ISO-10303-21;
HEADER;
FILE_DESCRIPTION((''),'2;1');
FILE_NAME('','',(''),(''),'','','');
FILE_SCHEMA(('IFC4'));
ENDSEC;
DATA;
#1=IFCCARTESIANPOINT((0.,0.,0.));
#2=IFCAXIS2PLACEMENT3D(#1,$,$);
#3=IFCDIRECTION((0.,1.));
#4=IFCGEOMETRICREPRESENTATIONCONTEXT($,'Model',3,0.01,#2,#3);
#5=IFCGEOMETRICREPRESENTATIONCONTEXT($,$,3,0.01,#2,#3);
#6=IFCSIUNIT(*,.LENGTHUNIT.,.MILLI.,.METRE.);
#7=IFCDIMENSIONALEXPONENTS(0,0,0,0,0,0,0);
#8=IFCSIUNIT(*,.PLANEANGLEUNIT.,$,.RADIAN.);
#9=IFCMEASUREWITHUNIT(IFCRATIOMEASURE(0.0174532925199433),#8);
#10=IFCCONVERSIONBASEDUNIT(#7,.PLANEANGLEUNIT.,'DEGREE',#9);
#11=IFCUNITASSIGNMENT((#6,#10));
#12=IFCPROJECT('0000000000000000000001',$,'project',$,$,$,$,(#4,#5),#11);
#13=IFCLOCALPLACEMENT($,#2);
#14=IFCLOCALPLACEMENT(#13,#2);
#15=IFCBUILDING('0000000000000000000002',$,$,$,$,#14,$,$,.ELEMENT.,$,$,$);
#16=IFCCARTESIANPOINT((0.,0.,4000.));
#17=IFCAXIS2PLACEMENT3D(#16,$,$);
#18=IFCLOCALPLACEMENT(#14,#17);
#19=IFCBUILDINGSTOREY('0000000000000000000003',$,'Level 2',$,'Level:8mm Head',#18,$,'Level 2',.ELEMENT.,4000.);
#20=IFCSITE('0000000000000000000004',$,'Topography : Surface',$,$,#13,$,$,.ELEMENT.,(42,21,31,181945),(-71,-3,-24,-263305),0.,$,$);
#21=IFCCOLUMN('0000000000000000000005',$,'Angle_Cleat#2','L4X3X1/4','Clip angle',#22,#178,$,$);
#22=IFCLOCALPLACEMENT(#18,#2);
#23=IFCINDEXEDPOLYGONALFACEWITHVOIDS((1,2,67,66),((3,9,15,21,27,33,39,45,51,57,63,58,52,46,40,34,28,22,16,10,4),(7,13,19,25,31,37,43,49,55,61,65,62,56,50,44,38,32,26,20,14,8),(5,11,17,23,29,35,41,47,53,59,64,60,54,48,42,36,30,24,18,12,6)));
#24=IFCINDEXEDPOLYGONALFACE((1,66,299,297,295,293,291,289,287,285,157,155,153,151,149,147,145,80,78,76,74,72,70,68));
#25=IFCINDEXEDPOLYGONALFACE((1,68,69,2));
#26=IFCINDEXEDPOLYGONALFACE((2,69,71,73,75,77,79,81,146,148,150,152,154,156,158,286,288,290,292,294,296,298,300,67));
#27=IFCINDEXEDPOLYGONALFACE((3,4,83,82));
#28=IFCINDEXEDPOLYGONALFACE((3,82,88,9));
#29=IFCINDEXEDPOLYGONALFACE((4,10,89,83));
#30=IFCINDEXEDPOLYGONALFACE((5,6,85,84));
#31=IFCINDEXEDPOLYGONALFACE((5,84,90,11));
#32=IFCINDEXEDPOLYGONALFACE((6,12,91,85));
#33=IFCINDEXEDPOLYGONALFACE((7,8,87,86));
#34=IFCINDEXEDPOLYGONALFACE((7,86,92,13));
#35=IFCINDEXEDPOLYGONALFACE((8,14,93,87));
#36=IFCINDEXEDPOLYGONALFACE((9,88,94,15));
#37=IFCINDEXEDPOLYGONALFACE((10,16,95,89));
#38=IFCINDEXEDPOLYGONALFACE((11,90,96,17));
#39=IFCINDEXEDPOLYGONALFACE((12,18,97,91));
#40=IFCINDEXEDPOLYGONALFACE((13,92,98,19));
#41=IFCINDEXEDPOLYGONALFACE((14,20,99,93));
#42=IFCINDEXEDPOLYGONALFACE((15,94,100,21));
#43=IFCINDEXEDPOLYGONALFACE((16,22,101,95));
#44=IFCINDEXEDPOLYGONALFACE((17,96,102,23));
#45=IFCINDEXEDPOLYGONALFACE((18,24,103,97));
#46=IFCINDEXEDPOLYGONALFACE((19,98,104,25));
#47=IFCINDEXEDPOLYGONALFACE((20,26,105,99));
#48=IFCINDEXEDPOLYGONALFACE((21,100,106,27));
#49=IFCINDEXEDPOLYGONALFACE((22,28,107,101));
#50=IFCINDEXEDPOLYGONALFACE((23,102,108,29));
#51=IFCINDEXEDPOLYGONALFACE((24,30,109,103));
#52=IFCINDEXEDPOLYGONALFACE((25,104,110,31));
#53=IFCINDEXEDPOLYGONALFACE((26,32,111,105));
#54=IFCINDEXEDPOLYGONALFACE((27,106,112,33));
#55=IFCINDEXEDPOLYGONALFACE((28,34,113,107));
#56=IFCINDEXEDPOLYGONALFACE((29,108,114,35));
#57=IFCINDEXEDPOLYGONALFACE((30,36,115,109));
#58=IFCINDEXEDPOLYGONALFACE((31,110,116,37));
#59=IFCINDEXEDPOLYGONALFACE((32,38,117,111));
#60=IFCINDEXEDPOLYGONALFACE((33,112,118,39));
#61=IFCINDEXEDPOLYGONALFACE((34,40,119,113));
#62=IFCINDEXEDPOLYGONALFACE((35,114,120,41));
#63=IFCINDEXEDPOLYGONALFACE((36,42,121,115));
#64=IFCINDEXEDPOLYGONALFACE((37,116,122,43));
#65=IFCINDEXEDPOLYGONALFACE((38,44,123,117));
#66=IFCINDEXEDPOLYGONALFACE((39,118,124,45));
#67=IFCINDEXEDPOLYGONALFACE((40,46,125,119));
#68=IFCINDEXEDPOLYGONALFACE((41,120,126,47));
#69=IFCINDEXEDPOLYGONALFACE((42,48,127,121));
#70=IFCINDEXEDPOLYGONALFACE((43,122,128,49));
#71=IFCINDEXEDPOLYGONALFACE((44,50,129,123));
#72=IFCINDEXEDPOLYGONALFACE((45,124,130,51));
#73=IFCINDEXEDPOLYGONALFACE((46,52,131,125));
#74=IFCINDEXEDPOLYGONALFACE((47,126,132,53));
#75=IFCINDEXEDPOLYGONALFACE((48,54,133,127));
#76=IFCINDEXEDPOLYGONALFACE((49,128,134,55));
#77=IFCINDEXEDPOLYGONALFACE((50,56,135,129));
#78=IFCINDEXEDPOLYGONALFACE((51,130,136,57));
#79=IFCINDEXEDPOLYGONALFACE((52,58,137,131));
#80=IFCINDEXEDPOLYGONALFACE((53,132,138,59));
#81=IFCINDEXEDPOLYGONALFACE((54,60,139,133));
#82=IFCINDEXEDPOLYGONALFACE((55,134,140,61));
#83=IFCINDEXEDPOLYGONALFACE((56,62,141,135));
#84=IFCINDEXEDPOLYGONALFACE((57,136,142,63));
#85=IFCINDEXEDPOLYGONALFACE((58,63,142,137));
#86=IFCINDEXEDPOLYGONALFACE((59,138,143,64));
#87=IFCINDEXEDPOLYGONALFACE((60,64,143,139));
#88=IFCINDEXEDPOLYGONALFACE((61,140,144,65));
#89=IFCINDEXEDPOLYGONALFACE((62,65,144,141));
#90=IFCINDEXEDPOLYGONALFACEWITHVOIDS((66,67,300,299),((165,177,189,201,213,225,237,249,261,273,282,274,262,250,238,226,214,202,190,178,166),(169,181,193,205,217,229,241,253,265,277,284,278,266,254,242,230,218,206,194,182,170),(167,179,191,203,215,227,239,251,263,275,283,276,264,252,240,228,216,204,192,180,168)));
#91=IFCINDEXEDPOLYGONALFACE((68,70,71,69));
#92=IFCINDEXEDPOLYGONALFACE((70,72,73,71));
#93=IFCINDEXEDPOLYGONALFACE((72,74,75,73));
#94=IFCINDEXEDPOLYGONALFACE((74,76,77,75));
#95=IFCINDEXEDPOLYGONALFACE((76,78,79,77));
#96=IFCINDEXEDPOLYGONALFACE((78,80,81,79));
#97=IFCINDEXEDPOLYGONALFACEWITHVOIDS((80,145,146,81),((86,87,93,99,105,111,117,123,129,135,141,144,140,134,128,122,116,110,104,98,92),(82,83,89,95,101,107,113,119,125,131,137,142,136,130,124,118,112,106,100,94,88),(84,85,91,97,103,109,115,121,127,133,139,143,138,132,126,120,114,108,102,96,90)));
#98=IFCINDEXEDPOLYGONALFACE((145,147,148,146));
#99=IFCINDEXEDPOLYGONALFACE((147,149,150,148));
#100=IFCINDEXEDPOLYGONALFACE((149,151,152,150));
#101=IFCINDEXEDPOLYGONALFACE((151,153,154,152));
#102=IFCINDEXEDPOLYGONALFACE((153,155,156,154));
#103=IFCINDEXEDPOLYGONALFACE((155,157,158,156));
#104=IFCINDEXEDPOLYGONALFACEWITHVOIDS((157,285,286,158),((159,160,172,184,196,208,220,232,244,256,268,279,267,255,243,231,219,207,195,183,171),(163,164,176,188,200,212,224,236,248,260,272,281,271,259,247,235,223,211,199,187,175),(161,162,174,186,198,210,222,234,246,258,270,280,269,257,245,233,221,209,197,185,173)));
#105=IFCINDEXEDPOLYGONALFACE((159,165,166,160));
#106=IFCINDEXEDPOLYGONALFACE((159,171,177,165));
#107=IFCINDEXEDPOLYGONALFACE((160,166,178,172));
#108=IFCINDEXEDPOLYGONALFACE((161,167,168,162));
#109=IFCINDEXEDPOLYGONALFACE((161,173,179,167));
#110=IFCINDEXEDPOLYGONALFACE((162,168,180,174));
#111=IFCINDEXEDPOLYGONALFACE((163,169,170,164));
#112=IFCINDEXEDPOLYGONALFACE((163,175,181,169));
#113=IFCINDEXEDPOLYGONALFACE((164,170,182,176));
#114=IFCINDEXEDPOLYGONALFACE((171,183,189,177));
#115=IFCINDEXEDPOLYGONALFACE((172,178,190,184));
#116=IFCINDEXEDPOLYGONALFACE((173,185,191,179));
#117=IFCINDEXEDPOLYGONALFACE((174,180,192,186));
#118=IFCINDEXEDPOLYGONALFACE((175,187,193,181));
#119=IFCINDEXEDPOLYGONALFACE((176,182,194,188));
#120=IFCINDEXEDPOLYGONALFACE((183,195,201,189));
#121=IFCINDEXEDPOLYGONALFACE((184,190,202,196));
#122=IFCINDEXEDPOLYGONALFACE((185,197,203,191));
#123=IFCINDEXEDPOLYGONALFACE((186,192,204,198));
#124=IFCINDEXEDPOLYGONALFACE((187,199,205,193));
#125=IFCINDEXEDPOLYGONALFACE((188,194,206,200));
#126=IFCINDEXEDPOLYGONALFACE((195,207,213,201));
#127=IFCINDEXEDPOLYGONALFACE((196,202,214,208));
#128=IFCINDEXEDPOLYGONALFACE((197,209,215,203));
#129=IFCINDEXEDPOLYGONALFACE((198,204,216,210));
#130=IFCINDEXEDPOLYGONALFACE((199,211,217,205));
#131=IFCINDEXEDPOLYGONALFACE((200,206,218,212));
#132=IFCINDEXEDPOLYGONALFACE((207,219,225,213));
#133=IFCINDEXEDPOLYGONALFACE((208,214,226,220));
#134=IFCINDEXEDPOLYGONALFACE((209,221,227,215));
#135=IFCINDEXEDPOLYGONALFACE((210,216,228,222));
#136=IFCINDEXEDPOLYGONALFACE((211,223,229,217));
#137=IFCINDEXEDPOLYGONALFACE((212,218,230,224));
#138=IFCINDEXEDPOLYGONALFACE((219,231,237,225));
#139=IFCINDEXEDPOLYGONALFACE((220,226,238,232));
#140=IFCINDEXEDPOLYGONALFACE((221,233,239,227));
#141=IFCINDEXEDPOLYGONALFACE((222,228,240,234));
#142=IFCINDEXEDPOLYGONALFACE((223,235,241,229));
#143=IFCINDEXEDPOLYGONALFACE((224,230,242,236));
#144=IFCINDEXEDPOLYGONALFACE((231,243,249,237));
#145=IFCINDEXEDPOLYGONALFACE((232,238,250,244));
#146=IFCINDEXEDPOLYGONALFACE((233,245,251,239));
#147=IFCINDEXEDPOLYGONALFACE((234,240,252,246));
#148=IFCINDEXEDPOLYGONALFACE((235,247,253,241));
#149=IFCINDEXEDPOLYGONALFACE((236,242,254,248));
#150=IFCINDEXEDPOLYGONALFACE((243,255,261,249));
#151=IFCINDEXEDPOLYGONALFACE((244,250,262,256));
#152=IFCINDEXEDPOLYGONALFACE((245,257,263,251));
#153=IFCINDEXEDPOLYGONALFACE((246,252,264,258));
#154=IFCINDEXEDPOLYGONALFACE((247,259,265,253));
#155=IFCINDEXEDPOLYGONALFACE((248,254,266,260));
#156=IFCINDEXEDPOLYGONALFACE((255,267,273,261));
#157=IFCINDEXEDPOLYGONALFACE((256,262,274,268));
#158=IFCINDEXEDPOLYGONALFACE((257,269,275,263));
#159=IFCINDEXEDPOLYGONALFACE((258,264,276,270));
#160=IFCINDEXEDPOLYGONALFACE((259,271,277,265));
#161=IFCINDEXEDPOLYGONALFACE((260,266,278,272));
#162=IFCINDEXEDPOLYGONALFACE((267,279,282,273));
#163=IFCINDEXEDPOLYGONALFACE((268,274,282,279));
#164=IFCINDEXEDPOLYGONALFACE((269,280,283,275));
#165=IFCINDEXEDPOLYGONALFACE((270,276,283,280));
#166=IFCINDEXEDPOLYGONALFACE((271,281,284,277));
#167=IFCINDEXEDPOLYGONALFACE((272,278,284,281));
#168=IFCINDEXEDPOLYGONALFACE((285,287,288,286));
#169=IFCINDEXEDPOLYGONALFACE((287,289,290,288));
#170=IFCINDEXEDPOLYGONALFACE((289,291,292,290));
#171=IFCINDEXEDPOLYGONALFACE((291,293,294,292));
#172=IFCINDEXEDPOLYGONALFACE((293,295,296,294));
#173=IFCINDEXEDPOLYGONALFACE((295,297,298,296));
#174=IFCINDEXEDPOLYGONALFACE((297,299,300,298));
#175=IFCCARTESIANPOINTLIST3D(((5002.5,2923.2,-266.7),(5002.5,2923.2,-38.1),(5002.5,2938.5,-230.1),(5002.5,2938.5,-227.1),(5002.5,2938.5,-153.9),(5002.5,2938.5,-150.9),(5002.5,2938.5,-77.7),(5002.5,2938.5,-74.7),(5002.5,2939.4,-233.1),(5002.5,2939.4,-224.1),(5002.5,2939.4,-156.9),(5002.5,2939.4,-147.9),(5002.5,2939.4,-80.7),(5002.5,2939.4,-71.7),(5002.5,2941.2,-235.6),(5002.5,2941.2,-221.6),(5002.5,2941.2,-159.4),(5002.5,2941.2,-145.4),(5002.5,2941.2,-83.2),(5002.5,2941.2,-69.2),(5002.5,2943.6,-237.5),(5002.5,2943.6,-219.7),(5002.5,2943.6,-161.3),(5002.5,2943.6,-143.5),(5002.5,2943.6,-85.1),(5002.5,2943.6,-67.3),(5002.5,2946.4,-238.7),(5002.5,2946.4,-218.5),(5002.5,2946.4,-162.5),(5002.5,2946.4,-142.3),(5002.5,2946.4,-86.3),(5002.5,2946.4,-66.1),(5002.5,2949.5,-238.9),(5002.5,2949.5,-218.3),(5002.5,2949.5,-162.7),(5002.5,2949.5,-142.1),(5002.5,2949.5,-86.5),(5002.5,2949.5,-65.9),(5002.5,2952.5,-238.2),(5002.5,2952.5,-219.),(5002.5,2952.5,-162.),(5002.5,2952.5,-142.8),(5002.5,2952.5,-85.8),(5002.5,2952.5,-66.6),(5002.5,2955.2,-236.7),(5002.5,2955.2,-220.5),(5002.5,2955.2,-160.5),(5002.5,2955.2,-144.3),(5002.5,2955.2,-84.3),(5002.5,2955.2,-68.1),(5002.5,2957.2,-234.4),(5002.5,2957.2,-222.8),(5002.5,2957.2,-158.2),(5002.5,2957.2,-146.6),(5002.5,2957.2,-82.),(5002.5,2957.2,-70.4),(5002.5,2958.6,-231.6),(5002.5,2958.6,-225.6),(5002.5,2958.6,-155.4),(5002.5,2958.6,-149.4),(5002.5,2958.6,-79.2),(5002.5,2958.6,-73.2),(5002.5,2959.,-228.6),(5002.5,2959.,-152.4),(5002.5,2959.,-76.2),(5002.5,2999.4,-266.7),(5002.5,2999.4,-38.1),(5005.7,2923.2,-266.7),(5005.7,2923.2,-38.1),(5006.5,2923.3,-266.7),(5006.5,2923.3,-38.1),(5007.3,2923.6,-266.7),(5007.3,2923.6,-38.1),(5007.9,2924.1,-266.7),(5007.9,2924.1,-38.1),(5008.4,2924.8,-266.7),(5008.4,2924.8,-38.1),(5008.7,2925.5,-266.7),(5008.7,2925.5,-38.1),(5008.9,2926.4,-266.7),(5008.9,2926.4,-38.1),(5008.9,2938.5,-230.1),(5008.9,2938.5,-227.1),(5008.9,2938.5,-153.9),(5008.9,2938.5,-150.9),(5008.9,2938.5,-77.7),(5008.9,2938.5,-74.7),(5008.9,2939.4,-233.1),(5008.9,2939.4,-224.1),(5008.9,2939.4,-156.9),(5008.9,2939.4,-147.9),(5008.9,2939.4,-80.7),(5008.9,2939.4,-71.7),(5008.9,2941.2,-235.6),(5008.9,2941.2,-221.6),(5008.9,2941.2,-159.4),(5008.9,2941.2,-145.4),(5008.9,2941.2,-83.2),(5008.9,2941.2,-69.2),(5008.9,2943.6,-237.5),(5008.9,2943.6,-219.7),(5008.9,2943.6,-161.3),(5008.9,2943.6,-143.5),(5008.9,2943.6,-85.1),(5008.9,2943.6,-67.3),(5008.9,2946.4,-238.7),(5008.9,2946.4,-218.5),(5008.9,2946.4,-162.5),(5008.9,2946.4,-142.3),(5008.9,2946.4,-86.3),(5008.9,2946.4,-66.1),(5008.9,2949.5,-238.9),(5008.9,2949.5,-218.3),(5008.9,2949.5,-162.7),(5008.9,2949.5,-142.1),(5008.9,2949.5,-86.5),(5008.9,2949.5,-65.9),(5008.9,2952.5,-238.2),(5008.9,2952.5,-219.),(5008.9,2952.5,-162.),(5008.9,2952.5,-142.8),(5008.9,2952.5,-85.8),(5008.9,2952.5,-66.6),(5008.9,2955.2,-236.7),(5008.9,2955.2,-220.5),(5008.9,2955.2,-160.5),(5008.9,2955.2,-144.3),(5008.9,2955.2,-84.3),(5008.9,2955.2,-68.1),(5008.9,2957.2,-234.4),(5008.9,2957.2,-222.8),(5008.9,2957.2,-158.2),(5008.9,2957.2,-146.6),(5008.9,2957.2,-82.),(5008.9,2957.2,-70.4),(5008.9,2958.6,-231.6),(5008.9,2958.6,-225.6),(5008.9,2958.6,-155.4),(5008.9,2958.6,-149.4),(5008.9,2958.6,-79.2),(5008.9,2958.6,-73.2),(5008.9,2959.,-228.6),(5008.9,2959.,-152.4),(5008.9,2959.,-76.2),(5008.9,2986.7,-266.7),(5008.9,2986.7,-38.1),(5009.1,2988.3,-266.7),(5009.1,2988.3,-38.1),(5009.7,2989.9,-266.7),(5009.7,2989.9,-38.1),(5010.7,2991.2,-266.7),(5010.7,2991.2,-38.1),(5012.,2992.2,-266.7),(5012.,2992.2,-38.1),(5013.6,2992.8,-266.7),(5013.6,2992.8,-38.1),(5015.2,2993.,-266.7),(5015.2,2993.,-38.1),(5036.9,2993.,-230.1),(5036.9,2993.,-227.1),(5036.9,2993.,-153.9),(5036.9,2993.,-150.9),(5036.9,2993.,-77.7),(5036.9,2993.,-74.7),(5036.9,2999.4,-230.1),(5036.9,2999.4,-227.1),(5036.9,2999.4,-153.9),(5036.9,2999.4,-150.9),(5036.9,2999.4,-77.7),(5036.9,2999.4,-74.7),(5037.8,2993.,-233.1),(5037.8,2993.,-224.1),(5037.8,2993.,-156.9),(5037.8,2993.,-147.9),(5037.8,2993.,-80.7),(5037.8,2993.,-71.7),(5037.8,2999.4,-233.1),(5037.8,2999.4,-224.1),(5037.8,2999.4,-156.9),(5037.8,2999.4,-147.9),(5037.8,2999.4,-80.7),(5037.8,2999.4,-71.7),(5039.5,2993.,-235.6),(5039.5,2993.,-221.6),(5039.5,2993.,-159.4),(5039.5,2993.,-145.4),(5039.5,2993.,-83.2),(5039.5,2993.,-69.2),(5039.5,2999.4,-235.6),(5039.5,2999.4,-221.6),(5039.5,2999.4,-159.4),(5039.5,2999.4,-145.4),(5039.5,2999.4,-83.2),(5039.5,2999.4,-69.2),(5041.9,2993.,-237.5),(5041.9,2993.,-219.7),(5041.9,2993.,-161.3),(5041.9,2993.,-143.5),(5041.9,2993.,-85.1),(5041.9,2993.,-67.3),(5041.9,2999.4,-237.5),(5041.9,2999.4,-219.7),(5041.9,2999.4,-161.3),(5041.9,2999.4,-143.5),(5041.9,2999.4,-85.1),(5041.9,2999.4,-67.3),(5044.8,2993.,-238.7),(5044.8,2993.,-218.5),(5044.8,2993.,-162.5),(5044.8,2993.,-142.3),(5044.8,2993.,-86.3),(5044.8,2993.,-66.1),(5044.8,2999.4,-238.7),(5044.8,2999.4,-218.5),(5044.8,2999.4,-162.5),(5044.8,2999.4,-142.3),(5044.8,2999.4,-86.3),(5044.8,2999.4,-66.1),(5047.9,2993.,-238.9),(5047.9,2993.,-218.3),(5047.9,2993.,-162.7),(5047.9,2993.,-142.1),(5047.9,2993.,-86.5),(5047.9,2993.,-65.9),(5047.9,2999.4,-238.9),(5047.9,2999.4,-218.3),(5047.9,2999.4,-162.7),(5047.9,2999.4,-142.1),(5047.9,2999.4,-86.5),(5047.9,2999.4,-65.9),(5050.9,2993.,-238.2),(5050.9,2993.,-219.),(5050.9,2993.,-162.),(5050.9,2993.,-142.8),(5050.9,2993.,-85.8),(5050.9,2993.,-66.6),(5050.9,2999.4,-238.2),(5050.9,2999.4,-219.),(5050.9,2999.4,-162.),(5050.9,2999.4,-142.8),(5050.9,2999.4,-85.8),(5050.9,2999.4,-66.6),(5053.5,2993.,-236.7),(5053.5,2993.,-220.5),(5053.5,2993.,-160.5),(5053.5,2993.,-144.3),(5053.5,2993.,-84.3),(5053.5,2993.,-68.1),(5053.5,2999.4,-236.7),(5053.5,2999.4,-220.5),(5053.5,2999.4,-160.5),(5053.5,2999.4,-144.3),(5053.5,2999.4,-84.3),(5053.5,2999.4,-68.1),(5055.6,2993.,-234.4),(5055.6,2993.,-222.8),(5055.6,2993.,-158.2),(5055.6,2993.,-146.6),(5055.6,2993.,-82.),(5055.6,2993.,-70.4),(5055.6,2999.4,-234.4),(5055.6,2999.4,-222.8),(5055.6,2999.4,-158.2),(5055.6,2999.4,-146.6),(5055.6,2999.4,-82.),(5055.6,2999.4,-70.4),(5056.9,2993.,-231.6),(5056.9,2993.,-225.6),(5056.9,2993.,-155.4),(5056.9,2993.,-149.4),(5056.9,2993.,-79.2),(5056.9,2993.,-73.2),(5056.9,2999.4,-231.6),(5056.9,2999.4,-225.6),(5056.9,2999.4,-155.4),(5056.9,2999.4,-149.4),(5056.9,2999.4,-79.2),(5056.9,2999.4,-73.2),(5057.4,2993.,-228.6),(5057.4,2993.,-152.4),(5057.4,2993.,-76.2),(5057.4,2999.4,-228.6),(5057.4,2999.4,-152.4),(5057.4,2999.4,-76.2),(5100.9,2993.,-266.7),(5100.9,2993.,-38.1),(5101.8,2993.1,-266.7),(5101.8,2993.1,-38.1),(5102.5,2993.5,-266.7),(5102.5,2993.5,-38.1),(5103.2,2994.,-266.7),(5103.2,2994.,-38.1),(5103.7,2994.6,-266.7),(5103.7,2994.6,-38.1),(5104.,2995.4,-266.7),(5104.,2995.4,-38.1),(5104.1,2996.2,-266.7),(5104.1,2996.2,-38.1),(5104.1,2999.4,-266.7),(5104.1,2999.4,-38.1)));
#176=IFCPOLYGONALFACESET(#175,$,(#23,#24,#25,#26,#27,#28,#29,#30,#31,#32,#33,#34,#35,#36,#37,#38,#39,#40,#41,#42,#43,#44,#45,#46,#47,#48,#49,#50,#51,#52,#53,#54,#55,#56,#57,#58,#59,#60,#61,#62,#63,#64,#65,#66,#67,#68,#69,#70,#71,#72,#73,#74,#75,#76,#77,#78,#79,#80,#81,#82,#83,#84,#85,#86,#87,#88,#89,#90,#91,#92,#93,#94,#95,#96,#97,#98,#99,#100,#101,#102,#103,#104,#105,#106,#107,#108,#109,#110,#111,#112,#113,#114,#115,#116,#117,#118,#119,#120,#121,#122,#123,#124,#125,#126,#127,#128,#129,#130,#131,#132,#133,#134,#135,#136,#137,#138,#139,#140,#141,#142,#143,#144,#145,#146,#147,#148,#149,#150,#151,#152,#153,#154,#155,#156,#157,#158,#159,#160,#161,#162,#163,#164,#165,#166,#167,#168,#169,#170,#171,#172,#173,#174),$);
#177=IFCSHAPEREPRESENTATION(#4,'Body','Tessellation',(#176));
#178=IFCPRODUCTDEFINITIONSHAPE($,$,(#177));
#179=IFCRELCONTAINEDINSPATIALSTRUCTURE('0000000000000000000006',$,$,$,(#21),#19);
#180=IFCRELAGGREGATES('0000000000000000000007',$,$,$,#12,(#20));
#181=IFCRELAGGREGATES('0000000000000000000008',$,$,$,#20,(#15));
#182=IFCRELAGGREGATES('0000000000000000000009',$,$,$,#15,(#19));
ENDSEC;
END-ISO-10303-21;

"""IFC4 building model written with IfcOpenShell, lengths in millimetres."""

from ifc_helpers import new_model, entity, si_unit, converted_unit, direction, frame, frame_2d, origin, origin_2d_with_axis, place, context, project, spatial, circle, l_section, extrude, element, save


model = new_model("IFC4")

# Units and contexts
model_context = context("Model", 3, precision=0.01, world=origin(), true_north=direction((0.0, 1.0)))
context_of_model = context(None, 3, precision=0.01, world=origin(), true_north=direction((0.0, 1.0)))
ifc_project = project(units=[si_unit("LENGTHUNIT", "METRE", prefix="MILLI"), converted_unit("PLANEANGLEUNIT", "DEGREE", entity("IfcRatioMeasure", 0.0174532925199433), si_unit("PLANEANGLEUNIT", "RADIAN"), dimensions=[0, 0, 0, 0, 0, 0, 0])], contexts=[model_context, context_of_model])

# Site, building, storey
site_placement = place(None, origin())
site = spatial("IfcSite", under=ifc_project, at=site_placement, Name="Topography : Surface", CompositionType="ELEMENT", RefLatitude=(42, 21, 31, 181945), RefLongitude=(-71, -3, -24, -263305), RefElevation=0.0)
building_placement = place(site_placement, origin())
building = spatial("IfcBuilding", under=site, at=building_placement, CompositionType="ELEMENT")
storey_placement = place(building_placement, frame((0.0, 0.0, 4000.0)))
storey = spatial("IfcBuildingStorey", under=building, at=storey_placement, Name="Level 2", ObjectType="Level:8mm Head", LongName="Level 2", CompositionType="ELEMENT", Elevation=4000.0)

# Column, openings
column_1_placement = place(storey_placement, frame((5033.6, 2981.1, -38.1), z_axis=(0.0, 0.0, 1.0), x_axis=(0.0, -1.0, 0.0)))
column_1 = element("IfcColumn", 1, at=column_1_placement, inside=storey, Name="Angle_Cleat#2", Description="L4X3X1/4", ObjectType="Clip angle", context=model_context, shape_type="SweptSolid", body=[
    extrude(l_section(Depth=101.6, Width=76.2, Thickness=6.3, FilletRadius=6.3, EdgeRadius=3.2, at=frame_2d((19.8, 19.7))), origin(), (0.0, 0.0, -1.0), 228.6),
])
opening_1_placement = place(column_1_placement, frame((32.4, -31.5, -114.3), z_axis=(0.0, 1.0, 0.0), x_axis=(-1.0, 0.0, 0.0)))
element("IfcOpeningElement", 2, at=opening_1_placement, cuts=column_1, ObjectType="Opening", context=model_context, shape_type="SweptSolid", body=[
    extrude(circle(Radius=10.3, at=origin_2d_with_axis()), origin(), (0.0, 0.0, 1.0), 7.3),
])
opening_2_placement = place(column_1_placement, frame((32.4, -31.5, -114.3), z_axis=(0.0, 1.0, 0.0), x_axis=(-1.0, 0.0, 0.0)))
element("IfcOpeningElement", 3, at=opening_2_placement, cuts=column_1, ObjectType="Opening", context=model_context, shape_type="SweptSolid", body=[
    extrude(circle(Radius=10.3, at=frame_2d((0.0, 76.2), x_axis=(1.0, 0.0))), origin(), (0.0, 0.0, 1.0), 7.3),
])
opening_3_placement = place(column_1_placement, frame((32.4, -31.5, -114.3), z_axis=(0.0, 1.0, 0.0), x_axis=(-1.0, 0.0, 0.0)))
element("IfcOpeningElement", 4, at=opening_3_placement, cuts=column_1, ObjectType="Opening", context=model_context, shape_type="SweptSolid", body=[
    extrude(circle(Radius=10.3, at=frame_2d((0.0, -76.2), x_axis=(1.0, 0.0))), origin(), (0.0, 0.0, 1.0), 7.3),
])
opening_4_placement = place(column_1_placement, frame((-11.6, 13.5, -114.3), z_axis=(-1.0, 0.0, 0.0), x_axis=(0.0, 1.0, 0.0)))
element("IfcOpeningElement", 5, at=opening_4_placement, cuts=column_1, ObjectType="Opening", context=model_context, shape_type="SweptSolid", body=[
    extrude(circle(Radius=10.3, at=origin_2d_with_axis()), origin(), (0.0, 0.0, 1.0), 7.3),
])
opening_5_placement = place(column_1_placement, frame((-11.6, 13.5, -114.3), z_axis=(-1.0, 0.0, 0.0), x_axis=(0.0, 1.0, 0.0)))
element("IfcOpeningElement", 6, at=opening_5_placement, cuts=column_1, ObjectType="Opening", context=model_context, shape_type="SweptSolid", body=[
    extrude(circle(Radius=10.3, at=frame_2d((0.0, 76.2), x_axis=(1.0, 0.0))), origin(), (0.0, 0.0, 1.0), 7.3),
])
opening_6_placement = place(column_1_placement, frame((-11.6, 13.5, -114.3), z_axis=(-1.0, 0.0, 0.0), x_axis=(0.0, 1.0, 0.0)))
element("IfcOpeningElement", 7, at=opening_6_placement, cuts=column_1, ObjectType="Opening", context=model_context, shape_type="SweptSolid", body=[
    extrude(circle(Radius=10.3, at=frame_2d((0.0, -76.2), x_axis=(1.0, 0.0))), origin(), (0.0, 0.0, 1.0), 7.3),
])

save(model, "model.ifc")
